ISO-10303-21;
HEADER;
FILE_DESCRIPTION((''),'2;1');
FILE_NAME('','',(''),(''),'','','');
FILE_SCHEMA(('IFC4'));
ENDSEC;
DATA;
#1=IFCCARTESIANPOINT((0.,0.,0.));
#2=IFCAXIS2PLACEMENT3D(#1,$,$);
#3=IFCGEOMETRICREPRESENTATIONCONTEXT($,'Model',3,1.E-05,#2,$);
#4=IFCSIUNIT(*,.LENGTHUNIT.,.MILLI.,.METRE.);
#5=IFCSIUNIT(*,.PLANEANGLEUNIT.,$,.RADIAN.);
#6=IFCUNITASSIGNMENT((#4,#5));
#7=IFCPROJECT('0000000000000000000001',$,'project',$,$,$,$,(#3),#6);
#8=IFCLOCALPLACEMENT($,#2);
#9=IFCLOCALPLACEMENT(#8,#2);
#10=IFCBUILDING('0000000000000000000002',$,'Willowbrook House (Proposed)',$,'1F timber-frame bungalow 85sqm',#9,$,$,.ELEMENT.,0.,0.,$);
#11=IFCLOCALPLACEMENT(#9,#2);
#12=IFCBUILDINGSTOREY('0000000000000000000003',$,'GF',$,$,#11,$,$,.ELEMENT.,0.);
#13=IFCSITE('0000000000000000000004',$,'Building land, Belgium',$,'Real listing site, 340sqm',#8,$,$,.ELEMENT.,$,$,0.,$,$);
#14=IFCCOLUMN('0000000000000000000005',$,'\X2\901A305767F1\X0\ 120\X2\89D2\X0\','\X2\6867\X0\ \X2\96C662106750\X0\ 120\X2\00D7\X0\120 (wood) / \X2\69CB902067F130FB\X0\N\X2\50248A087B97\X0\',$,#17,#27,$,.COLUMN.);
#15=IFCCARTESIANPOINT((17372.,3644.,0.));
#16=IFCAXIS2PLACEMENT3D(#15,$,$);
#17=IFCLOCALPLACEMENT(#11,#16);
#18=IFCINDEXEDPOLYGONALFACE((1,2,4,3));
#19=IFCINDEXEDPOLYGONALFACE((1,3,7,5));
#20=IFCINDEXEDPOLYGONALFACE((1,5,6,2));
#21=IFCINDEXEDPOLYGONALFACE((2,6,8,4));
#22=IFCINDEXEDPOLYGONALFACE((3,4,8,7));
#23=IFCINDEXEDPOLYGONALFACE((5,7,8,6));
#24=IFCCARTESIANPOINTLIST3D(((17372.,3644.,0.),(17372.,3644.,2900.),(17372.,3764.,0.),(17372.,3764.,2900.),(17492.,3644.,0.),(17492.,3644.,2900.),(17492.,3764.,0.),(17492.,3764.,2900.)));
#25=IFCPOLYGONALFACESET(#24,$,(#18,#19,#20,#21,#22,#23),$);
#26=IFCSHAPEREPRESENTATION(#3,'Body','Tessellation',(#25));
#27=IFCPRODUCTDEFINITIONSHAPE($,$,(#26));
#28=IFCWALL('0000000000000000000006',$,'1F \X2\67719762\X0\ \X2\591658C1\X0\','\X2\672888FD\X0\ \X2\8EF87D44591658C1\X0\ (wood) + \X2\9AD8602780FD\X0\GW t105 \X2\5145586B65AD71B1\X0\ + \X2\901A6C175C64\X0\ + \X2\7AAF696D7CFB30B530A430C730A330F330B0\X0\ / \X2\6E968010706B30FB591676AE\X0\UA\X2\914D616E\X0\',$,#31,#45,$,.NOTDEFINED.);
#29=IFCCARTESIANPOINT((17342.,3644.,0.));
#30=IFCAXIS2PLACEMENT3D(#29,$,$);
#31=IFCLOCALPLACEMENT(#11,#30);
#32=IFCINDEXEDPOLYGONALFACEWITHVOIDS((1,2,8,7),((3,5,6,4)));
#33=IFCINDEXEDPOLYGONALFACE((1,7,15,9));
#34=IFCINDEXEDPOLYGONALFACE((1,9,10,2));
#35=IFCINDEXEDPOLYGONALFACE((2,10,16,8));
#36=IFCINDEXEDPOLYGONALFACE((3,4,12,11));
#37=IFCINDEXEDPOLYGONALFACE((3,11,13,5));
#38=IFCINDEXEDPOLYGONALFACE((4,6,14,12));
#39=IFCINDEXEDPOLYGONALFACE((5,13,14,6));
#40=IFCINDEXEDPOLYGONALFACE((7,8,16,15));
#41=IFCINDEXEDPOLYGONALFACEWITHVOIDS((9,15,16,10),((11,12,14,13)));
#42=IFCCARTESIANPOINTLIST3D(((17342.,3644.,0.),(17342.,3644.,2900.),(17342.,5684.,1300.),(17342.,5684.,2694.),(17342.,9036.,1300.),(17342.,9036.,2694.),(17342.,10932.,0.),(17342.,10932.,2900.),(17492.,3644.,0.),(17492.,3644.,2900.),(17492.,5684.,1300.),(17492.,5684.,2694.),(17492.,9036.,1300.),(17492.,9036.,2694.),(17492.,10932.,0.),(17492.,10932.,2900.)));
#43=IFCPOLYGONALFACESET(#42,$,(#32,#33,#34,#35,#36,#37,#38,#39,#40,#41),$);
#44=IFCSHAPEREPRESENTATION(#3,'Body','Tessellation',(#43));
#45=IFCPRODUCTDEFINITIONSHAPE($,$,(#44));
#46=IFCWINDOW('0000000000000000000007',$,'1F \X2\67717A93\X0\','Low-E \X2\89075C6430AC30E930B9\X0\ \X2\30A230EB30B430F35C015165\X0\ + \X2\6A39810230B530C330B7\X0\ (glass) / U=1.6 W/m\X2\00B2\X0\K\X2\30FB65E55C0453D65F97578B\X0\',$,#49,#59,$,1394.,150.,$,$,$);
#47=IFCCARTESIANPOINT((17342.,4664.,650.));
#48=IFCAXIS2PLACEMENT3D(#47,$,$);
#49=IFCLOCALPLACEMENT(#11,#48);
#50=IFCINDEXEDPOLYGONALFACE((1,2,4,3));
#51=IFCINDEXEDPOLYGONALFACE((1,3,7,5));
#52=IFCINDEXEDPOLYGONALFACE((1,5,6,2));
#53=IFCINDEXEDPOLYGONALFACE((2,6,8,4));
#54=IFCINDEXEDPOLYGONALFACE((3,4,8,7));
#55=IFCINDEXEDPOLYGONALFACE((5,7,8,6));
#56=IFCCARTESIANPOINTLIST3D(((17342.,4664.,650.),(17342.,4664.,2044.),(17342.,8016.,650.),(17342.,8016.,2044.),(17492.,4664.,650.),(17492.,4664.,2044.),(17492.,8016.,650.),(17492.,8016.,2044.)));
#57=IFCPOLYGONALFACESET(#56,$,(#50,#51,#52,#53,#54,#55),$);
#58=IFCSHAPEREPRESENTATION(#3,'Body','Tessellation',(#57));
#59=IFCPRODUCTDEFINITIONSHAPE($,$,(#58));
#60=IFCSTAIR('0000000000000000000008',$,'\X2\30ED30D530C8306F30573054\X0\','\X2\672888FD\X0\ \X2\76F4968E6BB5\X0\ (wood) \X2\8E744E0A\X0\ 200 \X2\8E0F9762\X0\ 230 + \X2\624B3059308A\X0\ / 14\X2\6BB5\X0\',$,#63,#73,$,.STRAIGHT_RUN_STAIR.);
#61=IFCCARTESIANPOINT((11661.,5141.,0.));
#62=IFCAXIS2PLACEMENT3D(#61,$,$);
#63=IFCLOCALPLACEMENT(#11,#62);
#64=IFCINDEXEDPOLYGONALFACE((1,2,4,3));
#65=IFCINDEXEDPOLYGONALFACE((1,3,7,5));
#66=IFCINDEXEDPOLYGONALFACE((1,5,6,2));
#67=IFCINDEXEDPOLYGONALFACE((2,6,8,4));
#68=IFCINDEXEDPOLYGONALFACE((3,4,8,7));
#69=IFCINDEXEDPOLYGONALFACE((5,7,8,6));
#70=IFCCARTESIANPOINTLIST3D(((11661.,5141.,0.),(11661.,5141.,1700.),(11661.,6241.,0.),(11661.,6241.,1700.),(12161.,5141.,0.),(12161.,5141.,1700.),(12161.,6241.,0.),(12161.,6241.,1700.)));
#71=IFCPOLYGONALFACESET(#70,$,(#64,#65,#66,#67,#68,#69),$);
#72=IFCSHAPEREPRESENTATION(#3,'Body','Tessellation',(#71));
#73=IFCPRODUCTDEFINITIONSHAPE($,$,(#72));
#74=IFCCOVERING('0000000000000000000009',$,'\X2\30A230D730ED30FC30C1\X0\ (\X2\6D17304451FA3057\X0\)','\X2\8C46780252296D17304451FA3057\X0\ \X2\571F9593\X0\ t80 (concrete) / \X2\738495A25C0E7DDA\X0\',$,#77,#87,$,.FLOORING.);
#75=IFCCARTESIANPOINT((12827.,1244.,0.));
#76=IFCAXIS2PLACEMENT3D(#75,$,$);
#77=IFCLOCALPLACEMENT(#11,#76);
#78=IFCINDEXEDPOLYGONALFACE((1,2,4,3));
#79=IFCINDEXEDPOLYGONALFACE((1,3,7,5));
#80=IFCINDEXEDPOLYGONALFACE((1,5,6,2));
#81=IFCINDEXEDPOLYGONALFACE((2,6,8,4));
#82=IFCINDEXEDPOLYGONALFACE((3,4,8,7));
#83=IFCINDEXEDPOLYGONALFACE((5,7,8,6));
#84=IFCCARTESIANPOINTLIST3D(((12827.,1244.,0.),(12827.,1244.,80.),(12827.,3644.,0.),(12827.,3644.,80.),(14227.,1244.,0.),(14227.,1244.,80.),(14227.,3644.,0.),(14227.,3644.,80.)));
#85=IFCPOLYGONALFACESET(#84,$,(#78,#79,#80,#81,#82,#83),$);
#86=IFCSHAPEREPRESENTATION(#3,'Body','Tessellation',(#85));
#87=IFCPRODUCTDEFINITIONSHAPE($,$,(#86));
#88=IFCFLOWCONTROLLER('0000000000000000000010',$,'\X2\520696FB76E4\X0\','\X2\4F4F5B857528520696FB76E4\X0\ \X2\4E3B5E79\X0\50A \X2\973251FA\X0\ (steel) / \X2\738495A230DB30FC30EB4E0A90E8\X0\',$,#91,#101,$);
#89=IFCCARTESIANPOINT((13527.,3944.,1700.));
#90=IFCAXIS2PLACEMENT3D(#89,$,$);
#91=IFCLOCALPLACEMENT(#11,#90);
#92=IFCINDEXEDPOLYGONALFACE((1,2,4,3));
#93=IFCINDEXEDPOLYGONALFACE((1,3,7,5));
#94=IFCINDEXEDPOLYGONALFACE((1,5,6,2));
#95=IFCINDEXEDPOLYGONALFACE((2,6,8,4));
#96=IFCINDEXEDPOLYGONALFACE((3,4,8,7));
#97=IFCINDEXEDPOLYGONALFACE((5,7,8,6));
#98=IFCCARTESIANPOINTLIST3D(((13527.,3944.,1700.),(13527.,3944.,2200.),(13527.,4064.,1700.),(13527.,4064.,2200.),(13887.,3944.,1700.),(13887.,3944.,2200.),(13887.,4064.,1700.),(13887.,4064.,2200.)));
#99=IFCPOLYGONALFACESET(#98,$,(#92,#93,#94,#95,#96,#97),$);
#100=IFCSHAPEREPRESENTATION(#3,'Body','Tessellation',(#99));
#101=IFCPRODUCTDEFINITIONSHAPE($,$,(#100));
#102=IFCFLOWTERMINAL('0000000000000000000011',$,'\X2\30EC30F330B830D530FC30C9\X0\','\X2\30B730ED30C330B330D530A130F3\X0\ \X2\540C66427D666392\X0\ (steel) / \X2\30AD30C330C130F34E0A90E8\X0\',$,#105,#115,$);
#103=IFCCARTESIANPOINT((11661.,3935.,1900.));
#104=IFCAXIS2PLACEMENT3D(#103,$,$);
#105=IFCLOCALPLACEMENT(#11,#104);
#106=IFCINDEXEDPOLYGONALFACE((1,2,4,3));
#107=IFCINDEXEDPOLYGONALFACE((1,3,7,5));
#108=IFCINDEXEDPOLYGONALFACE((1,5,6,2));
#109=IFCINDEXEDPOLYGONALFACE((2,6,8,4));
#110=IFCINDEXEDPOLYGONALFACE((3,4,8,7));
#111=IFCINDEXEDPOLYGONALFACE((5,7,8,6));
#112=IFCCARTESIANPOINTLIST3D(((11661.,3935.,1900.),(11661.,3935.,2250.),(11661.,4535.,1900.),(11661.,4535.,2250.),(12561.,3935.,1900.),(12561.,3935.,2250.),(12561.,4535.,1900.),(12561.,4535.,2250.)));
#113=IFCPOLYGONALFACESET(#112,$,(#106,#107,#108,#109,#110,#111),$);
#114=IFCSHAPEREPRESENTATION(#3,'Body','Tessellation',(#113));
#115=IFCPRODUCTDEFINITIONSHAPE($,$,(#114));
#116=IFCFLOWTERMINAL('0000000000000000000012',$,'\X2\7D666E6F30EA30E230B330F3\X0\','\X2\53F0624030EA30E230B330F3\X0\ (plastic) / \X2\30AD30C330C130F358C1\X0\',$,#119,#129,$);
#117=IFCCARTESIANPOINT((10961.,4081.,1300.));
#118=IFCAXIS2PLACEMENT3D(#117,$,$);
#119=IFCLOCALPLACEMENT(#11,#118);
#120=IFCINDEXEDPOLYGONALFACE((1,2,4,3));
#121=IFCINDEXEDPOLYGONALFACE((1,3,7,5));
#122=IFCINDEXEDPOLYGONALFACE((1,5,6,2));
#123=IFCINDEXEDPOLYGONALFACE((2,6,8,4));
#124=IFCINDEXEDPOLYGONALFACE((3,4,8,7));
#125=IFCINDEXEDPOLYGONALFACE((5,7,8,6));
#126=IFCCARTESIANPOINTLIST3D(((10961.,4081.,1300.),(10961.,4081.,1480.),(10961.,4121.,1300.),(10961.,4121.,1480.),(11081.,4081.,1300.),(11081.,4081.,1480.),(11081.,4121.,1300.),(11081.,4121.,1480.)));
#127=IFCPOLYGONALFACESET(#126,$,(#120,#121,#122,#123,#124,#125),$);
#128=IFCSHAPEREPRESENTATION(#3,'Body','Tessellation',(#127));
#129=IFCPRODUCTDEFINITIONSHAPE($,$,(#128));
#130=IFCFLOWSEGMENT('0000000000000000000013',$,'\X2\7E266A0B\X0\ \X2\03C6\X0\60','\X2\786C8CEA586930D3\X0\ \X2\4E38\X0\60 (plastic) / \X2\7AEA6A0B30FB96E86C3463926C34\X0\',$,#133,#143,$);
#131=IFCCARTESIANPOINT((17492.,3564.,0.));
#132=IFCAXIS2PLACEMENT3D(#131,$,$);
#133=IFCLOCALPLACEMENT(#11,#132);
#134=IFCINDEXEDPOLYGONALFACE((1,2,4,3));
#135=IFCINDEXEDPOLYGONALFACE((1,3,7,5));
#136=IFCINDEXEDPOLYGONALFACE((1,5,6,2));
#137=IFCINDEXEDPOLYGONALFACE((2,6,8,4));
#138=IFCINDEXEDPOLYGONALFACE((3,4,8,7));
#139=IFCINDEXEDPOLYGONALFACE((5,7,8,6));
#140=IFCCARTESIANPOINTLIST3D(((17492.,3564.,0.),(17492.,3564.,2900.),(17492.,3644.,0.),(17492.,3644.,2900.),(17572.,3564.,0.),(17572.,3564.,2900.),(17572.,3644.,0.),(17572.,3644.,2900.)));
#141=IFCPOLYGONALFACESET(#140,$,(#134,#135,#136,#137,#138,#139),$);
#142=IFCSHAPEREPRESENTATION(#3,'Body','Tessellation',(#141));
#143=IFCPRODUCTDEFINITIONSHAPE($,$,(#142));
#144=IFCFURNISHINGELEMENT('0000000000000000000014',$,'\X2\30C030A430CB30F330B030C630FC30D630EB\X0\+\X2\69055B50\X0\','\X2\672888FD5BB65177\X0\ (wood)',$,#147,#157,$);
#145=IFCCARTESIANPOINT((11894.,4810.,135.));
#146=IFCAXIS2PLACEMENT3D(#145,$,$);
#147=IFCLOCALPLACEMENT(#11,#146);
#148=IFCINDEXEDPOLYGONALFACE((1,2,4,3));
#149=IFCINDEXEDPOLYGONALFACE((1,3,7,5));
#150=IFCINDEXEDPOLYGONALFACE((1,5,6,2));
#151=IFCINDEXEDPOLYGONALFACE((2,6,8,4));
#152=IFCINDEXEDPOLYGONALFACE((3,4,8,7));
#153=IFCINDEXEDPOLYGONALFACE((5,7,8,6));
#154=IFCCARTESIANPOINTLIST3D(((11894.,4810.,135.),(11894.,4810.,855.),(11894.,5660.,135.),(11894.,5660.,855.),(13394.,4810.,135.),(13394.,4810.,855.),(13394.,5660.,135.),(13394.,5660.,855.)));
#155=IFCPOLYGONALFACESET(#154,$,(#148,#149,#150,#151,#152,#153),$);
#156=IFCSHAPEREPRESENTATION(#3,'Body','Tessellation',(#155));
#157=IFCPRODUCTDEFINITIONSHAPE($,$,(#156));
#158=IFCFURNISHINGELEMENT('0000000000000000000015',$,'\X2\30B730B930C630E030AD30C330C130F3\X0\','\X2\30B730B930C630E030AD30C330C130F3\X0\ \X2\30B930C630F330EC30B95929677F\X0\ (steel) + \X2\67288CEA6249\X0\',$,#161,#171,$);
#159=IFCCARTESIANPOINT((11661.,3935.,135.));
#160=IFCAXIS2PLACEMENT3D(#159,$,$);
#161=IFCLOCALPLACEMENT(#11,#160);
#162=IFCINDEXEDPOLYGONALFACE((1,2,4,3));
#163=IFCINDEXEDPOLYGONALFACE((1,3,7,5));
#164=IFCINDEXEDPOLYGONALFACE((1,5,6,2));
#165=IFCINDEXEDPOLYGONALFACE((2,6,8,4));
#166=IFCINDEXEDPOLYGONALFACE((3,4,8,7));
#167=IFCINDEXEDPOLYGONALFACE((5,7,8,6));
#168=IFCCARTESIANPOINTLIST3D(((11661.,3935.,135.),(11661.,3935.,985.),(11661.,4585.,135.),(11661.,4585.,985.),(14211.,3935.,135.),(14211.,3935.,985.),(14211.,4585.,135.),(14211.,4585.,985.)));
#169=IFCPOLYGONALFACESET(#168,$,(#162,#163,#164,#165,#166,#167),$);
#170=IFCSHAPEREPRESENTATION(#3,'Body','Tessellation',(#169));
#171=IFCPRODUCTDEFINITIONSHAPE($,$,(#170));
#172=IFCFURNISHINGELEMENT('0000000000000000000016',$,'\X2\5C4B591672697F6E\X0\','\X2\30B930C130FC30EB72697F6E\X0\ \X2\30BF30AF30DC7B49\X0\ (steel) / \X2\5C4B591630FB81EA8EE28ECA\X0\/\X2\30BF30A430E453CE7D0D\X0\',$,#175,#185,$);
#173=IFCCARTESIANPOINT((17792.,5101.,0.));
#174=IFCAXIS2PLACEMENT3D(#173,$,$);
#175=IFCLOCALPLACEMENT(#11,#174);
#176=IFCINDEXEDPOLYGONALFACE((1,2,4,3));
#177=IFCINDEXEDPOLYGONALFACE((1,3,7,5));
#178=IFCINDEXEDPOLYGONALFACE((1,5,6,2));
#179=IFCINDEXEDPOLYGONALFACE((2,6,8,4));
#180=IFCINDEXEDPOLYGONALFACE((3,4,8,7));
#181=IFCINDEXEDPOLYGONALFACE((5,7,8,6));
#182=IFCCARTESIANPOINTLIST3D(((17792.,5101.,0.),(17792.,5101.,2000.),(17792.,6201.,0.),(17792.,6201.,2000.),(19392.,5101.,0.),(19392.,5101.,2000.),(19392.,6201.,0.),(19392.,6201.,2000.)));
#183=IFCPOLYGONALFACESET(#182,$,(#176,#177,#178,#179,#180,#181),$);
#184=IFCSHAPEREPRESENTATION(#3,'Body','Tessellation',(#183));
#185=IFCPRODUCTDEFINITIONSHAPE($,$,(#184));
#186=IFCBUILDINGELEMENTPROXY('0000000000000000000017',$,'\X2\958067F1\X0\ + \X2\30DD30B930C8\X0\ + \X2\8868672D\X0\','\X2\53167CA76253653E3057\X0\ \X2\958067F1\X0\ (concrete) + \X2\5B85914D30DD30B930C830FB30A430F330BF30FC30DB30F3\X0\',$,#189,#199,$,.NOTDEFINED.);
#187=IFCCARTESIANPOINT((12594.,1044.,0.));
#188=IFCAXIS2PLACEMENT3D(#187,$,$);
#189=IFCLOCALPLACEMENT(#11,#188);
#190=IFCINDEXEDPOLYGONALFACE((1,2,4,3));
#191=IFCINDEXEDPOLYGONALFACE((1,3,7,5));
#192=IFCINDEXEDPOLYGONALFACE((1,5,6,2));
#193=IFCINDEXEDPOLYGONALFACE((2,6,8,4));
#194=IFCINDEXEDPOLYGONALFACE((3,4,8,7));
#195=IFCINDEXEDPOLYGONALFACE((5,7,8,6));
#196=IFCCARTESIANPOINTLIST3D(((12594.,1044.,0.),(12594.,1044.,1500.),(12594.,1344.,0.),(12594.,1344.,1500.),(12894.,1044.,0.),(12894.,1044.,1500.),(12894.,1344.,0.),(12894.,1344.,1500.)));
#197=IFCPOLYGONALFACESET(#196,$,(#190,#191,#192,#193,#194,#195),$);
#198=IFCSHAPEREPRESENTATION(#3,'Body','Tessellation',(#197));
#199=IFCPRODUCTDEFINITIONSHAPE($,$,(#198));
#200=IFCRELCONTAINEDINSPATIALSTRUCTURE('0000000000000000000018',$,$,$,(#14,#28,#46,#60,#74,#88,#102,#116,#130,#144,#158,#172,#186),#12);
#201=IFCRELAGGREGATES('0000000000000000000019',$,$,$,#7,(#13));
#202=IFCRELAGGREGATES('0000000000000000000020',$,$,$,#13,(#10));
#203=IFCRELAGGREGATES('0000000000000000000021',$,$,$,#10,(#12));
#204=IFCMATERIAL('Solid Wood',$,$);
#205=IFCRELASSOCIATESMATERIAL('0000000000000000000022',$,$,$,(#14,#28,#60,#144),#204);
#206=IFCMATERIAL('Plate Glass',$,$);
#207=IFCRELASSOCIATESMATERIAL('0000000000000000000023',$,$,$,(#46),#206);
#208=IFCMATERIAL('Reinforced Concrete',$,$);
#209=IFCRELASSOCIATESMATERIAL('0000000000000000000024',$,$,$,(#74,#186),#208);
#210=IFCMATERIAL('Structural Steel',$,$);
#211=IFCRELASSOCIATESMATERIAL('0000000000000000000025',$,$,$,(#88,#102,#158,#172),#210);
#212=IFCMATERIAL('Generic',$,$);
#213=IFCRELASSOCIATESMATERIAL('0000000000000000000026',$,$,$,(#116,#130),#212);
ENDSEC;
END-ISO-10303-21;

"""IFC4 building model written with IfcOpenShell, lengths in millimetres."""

from ifc_helpers import new_model, si_unit, frame, frame_2d, origin, place, context, project, spatial, rectangle, extrude, material, element, fill, save


model = new_model("IFC4")

# Units and contexts
model_context = context("Model", 3, precision=1e-05, world=origin())
ifc_project = project(units=[si_unit("LENGTHUNIT", "METRE", prefix="MILLI"), si_unit("PLANEANGLEUNIT", "RADIAN")], contexts=[model_context])

# Site, building, storey
site_placement = place(None, origin())
site = spatial("IfcSite", under=ifc_project, at=site_placement, Name="Building land, Belgium", ObjectType="Real listing site, 340sqm", CompositionType="ELEMENT", RefElevation=0.0)
building_placement = place(site_placement, origin())
building = spatial("IfcBuilding", under=site, at=building_placement, Name="Willowbrook House (Proposed)", ObjectType="1F timber-frame bungalow 85sqm", CompositionType="ELEMENT", ElevationOfRefHeight=0.0, ElevationOfTerrain=0.0)
storey_placement = place(building_placement, origin())
storey = spatial("IfcBuildingStorey", under=building, at=storey_placement, Name="GF", CompositionType="ELEMENT", Elevation=0.0)

# Column
ifc_material_1 = material(Name="Solid Wood")
column_1_placement = place(storey_placement, frame((17372.0, 3644.0, 0.0)))
element("IfcColumn", 1, at=column_1_placement, inside=storey, material=ifc_material_1, Name="通し柱 120角", Description="桧 集成材 120×120 (wood) / 構造柱・N値計算", PredefinedType="COLUMN", context=model_context, shape_type="SweptSolid", body=[
    extrude(rectangle(XDim=120.0, YDim=120.0, at=frame_2d((60.0, 60.0))), frame((17372.0, 3644.0, 0.0)), (0.0, 0.0, 1.0), 2900.0),
])

# Wall, opening, window
wall_1_placement = place(storey_placement, frame((17342.0, 3644.0, 0.0)))
wall_1 = element("IfcWall", 2, at=wall_1_placement, inside=storey, material=ifc_material_1, Name="1F 東面 外壁", Description="木製 軸組外壁 (wood) + 高性能GW t105 充填断熱 + 通気層 + 窯業系サイディング / 準耐火・外皮UA配慮", PredefinedType="NOTDEFINED", context=model_context, shape_type="SweptSolid", body=[
    extrude(rectangle(XDim=150.0, YDim=7288.0, at=frame_2d((75.0, 3644.0))), frame((17342.0, 3644.0, 0.0)), (0.0, 0.0, 1.0), 2900.0),
])
opening_placement = place(storey_placement, frame((17342.0, 4664.0, 650.0)))
opening = element("IfcOpeningElement", 3, at=opening_placement, cuts=wall_1, PredefinedType="NOTDEFINED", context=model_context, shape_type="SweptSolid", body=[
    extrude(rectangle(XDim=150.0, YDim=3352.0, at=frame_2d((75.0, 1676.0))), frame((17342.0, 4664.0, 650.0)), (0.0, 0.0, 1.0), 1394.0),
])
ifc_material_2 = material(Name="Plate Glass")
window_placement = place(storey_placement, frame((17342.0, 4664.0, 650.0)))
window = element("IfcWindow", 4, at=window_placement, inside=storey, material=ifc_material_2, Name="1F 東窓", Description="Low-E 複層ガラス アルゴン封入 + 樹脂サッシ (glass) / U=1.6 W/m²K・日射取得型", OverallHeight=1394.0, OverallWidth=150.0, context=model_context, shape_type="SweptSolid", body=[
    extrude(rectangle(XDim=150.0, YDim=3352.0, at=frame_2d((75.0, 1676.0))), frame((17342.0, 4664.0, 650.0)), (0.0, 0.0, 1.0), 1394.0),
])
fill(opening, window)

# Stair
stair_placement = place(storey_placement, frame((11661.0, 5141.0, 0.0)))
element("IfcStair", 5, at=stair_placement, inside=storey, material=ifc_material_1, Name="ロフトはしご", Description="木製 直階段 (wood) 蹴上 200 踏面 230 + 手すり / 14段", PredefinedType="STRAIGHT_RUN_STAIR", context=model_context, shape_type="SweptSolid", body=[
    extrude(rectangle(XDim=500.0, YDim=1100.0, at=frame_2d((250.0, 550.0))), frame((11661.0, 5141.0, 0.0)), (0.0, 0.0, 1.0), 1700.0),
])

# Covering
ifc_material_3 = material(Name="Reinforced Concrete")
covering_placement = place(storey_placement, frame((12827.0, 1244.0, 0.0)))
element("IfcCovering", 6, at=covering_placement, inside=storey, material=ifc_material_3, Name="アプローチ (洗い出し)", Description="豆砂利洗い出し 土間 t80 (concrete) / 玄関導線", PredefinedType="FLOORING", context=model_context, shape_type="SweptSolid", body=[
    extrude(rectangle(XDim=1400.0, YDim=2400.0, at=frame_2d((700.0, 1200.0))), frame((12827.0, 1244.0, 0.0)), (0.0, 0.0, 1.0), 80.0),
])

# Flow controller
ifc_material_4 = material(Name="Structural Steel")
flow_controller_placement = place(storey_placement, frame((13527.0, 3944.0, 1700.0)))
element("IfcFlowController", 7, at=flow_controller_placement, inside=storey, material=ifc_material_4, Name="分電盤", Description="住宅用分電盤 主幹50A 露出 (steel) / 玄関ホール上部", context=model_context, shape_type="SweptSolid", body=[
    extrude(rectangle(XDim=360.0, YDim=120.0, at=frame_2d((180.0, 60.0))), frame((13527.0, 3944.0, 1700.0)), (0.0, 0.0, 1.0), 500.0),
])

# Flow terminals
flow_terminal_1_placement = place(storey_placement, frame((11661.0, 3935.0, 1900.0)))
element("IfcFlowTerminal", 8, at=flow_terminal_1_placement, inside=storey, material=ifc_material_4, Name="レンジフード", Description="シロッコファン 同時給排 (steel) / キッチン上部", context=model_context, shape_type="SweptSolid", body=[
    extrude(rectangle(XDim=900.0, YDim=600.0, at=frame_2d((450.0, 300.0))), frame((11661.0, 3935.0, 1900.0)), (0.0, 0.0, 1.0), 350.0),
])
ifc_material_5 = material(Name="Generic")
flow_terminal_2_placement = place(storey_placement, frame((10961.0, 4081.0, 1300.0)))
element("IfcFlowTerminal", 9, at=flow_terminal_2_placement, inside=storey, material=ifc_material_5, Name="給湯リモコン", Description="台所リモコン (plastic) / キッチン壁", context=model_context, shape_type="SweptSolid", body=[
    extrude(rectangle(XDim=120.0, YDim=40.0, at=frame_2d((60.0, 20.0))), frame((10961.0, 4081.0, 1300.0)), (0.0, 0.0, 1.0), 180.0),
])

# Flow segment
flow_segment_placement = place(storey_placement, frame((17492.0, 3564.0, 0.0)))
element("IfcFlowSegment", 10, at=flow_segment_placement, inside=storey, material=ifc_material_5, Name="縦樋 φ60", Description="硬質塩ビ 丸60 (plastic) / 竪樋・雨水排水", context=model_context, shape_type="SweptSolid", body=[
    extrude(rectangle(XDim=80.0, YDim=80.0, at=frame_2d((40.0, 40.0))), frame((17492.0, 3564.0, 0.0)), (0.0, 0.0, 1.0), 2900.0),
])

# Furnishing elements
furnishing_1_placement = place(storey_placement, frame((11894.0, 4810.0, 135.0)))
element("IfcFurnishingElement", 11, at=furnishing_1_placement, inside=storey, material=ifc_material_1, Name="ダイニングテーブル+椅子", Description="木製家具 (wood)", context=model_context, shape_type="SweptSolid", body=[
    extrude(rectangle(XDim=1500.0, YDim=850.0, at=frame_2d((750.0, 425.0))), frame((11894.0, 4810.0, 135.0)), (0.0, 0.0, 1.0), 720.0),
])
furnishing_2_placement = place(storey_placement, frame((11661.0, 3935.0, 135.0)))
element("IfcFurnishingElement", 12, at=furnishing_2_placement, inside=storey, material=ifc_material_4, Name="システムキッチン", Description="システムキッチン ステンレス天板 (steel) + 木質扉", context=model_context, shape_type="SweptSolid", body=[
    extrude(rectangle(XDim=2550.0, YDim=650.0, at=frame_2d((1275.0, 325.0))), frame((11661.0, 3935.0, 135.0)), (0.0, 0.0, 1.0), 850.0),
])
furnishing_3_placement = place(storey_placement, frame((17792.0, 5101.0, 0.0)))
element("IfcFurnishingElement", 13, at=furnishing_3_placement, inside=storey, material=ifc_material_4, Name="屋外物置", Description="スチール物置 タクボ等 (steel) / 屋外・自転車/タイヤ収納", context=model_context, shape_type="SweptSolid", body=[
    extrude(rectangle(XDim=1600.0, YDim=1100.0, at=frame_2d((800.0, 550.0))), frame((17792.0, 5101.0, 0.0)), (0.0, 0.0, 1.0), 2000.0),
])

# Building element proxy
proxy_placement = place(storey_placement, frame((12594.0, 1044.0, 0.0)))
element("IfcBuildingElementProxy", 14, at=proxy_placement, inside=storey, material=ifc_material_3, Name="門柱 + ポスト + 表札", Description="化粧打放し 門柱 (concrete) + 宅配ポスト・インターホン", PredefinedType="NOTDEFINED", context=model_context, shape_type="SweptSolid", body=[
    extrude(rectangle(XDim=300.0, YDim=300.0, at=frame_2d((150.0, 150.0))), frame((12594.0, 1044.0, 0.0)), (0.0, 0.0, 1.0), 1500.0),
])

save(model, "model.ifc")
